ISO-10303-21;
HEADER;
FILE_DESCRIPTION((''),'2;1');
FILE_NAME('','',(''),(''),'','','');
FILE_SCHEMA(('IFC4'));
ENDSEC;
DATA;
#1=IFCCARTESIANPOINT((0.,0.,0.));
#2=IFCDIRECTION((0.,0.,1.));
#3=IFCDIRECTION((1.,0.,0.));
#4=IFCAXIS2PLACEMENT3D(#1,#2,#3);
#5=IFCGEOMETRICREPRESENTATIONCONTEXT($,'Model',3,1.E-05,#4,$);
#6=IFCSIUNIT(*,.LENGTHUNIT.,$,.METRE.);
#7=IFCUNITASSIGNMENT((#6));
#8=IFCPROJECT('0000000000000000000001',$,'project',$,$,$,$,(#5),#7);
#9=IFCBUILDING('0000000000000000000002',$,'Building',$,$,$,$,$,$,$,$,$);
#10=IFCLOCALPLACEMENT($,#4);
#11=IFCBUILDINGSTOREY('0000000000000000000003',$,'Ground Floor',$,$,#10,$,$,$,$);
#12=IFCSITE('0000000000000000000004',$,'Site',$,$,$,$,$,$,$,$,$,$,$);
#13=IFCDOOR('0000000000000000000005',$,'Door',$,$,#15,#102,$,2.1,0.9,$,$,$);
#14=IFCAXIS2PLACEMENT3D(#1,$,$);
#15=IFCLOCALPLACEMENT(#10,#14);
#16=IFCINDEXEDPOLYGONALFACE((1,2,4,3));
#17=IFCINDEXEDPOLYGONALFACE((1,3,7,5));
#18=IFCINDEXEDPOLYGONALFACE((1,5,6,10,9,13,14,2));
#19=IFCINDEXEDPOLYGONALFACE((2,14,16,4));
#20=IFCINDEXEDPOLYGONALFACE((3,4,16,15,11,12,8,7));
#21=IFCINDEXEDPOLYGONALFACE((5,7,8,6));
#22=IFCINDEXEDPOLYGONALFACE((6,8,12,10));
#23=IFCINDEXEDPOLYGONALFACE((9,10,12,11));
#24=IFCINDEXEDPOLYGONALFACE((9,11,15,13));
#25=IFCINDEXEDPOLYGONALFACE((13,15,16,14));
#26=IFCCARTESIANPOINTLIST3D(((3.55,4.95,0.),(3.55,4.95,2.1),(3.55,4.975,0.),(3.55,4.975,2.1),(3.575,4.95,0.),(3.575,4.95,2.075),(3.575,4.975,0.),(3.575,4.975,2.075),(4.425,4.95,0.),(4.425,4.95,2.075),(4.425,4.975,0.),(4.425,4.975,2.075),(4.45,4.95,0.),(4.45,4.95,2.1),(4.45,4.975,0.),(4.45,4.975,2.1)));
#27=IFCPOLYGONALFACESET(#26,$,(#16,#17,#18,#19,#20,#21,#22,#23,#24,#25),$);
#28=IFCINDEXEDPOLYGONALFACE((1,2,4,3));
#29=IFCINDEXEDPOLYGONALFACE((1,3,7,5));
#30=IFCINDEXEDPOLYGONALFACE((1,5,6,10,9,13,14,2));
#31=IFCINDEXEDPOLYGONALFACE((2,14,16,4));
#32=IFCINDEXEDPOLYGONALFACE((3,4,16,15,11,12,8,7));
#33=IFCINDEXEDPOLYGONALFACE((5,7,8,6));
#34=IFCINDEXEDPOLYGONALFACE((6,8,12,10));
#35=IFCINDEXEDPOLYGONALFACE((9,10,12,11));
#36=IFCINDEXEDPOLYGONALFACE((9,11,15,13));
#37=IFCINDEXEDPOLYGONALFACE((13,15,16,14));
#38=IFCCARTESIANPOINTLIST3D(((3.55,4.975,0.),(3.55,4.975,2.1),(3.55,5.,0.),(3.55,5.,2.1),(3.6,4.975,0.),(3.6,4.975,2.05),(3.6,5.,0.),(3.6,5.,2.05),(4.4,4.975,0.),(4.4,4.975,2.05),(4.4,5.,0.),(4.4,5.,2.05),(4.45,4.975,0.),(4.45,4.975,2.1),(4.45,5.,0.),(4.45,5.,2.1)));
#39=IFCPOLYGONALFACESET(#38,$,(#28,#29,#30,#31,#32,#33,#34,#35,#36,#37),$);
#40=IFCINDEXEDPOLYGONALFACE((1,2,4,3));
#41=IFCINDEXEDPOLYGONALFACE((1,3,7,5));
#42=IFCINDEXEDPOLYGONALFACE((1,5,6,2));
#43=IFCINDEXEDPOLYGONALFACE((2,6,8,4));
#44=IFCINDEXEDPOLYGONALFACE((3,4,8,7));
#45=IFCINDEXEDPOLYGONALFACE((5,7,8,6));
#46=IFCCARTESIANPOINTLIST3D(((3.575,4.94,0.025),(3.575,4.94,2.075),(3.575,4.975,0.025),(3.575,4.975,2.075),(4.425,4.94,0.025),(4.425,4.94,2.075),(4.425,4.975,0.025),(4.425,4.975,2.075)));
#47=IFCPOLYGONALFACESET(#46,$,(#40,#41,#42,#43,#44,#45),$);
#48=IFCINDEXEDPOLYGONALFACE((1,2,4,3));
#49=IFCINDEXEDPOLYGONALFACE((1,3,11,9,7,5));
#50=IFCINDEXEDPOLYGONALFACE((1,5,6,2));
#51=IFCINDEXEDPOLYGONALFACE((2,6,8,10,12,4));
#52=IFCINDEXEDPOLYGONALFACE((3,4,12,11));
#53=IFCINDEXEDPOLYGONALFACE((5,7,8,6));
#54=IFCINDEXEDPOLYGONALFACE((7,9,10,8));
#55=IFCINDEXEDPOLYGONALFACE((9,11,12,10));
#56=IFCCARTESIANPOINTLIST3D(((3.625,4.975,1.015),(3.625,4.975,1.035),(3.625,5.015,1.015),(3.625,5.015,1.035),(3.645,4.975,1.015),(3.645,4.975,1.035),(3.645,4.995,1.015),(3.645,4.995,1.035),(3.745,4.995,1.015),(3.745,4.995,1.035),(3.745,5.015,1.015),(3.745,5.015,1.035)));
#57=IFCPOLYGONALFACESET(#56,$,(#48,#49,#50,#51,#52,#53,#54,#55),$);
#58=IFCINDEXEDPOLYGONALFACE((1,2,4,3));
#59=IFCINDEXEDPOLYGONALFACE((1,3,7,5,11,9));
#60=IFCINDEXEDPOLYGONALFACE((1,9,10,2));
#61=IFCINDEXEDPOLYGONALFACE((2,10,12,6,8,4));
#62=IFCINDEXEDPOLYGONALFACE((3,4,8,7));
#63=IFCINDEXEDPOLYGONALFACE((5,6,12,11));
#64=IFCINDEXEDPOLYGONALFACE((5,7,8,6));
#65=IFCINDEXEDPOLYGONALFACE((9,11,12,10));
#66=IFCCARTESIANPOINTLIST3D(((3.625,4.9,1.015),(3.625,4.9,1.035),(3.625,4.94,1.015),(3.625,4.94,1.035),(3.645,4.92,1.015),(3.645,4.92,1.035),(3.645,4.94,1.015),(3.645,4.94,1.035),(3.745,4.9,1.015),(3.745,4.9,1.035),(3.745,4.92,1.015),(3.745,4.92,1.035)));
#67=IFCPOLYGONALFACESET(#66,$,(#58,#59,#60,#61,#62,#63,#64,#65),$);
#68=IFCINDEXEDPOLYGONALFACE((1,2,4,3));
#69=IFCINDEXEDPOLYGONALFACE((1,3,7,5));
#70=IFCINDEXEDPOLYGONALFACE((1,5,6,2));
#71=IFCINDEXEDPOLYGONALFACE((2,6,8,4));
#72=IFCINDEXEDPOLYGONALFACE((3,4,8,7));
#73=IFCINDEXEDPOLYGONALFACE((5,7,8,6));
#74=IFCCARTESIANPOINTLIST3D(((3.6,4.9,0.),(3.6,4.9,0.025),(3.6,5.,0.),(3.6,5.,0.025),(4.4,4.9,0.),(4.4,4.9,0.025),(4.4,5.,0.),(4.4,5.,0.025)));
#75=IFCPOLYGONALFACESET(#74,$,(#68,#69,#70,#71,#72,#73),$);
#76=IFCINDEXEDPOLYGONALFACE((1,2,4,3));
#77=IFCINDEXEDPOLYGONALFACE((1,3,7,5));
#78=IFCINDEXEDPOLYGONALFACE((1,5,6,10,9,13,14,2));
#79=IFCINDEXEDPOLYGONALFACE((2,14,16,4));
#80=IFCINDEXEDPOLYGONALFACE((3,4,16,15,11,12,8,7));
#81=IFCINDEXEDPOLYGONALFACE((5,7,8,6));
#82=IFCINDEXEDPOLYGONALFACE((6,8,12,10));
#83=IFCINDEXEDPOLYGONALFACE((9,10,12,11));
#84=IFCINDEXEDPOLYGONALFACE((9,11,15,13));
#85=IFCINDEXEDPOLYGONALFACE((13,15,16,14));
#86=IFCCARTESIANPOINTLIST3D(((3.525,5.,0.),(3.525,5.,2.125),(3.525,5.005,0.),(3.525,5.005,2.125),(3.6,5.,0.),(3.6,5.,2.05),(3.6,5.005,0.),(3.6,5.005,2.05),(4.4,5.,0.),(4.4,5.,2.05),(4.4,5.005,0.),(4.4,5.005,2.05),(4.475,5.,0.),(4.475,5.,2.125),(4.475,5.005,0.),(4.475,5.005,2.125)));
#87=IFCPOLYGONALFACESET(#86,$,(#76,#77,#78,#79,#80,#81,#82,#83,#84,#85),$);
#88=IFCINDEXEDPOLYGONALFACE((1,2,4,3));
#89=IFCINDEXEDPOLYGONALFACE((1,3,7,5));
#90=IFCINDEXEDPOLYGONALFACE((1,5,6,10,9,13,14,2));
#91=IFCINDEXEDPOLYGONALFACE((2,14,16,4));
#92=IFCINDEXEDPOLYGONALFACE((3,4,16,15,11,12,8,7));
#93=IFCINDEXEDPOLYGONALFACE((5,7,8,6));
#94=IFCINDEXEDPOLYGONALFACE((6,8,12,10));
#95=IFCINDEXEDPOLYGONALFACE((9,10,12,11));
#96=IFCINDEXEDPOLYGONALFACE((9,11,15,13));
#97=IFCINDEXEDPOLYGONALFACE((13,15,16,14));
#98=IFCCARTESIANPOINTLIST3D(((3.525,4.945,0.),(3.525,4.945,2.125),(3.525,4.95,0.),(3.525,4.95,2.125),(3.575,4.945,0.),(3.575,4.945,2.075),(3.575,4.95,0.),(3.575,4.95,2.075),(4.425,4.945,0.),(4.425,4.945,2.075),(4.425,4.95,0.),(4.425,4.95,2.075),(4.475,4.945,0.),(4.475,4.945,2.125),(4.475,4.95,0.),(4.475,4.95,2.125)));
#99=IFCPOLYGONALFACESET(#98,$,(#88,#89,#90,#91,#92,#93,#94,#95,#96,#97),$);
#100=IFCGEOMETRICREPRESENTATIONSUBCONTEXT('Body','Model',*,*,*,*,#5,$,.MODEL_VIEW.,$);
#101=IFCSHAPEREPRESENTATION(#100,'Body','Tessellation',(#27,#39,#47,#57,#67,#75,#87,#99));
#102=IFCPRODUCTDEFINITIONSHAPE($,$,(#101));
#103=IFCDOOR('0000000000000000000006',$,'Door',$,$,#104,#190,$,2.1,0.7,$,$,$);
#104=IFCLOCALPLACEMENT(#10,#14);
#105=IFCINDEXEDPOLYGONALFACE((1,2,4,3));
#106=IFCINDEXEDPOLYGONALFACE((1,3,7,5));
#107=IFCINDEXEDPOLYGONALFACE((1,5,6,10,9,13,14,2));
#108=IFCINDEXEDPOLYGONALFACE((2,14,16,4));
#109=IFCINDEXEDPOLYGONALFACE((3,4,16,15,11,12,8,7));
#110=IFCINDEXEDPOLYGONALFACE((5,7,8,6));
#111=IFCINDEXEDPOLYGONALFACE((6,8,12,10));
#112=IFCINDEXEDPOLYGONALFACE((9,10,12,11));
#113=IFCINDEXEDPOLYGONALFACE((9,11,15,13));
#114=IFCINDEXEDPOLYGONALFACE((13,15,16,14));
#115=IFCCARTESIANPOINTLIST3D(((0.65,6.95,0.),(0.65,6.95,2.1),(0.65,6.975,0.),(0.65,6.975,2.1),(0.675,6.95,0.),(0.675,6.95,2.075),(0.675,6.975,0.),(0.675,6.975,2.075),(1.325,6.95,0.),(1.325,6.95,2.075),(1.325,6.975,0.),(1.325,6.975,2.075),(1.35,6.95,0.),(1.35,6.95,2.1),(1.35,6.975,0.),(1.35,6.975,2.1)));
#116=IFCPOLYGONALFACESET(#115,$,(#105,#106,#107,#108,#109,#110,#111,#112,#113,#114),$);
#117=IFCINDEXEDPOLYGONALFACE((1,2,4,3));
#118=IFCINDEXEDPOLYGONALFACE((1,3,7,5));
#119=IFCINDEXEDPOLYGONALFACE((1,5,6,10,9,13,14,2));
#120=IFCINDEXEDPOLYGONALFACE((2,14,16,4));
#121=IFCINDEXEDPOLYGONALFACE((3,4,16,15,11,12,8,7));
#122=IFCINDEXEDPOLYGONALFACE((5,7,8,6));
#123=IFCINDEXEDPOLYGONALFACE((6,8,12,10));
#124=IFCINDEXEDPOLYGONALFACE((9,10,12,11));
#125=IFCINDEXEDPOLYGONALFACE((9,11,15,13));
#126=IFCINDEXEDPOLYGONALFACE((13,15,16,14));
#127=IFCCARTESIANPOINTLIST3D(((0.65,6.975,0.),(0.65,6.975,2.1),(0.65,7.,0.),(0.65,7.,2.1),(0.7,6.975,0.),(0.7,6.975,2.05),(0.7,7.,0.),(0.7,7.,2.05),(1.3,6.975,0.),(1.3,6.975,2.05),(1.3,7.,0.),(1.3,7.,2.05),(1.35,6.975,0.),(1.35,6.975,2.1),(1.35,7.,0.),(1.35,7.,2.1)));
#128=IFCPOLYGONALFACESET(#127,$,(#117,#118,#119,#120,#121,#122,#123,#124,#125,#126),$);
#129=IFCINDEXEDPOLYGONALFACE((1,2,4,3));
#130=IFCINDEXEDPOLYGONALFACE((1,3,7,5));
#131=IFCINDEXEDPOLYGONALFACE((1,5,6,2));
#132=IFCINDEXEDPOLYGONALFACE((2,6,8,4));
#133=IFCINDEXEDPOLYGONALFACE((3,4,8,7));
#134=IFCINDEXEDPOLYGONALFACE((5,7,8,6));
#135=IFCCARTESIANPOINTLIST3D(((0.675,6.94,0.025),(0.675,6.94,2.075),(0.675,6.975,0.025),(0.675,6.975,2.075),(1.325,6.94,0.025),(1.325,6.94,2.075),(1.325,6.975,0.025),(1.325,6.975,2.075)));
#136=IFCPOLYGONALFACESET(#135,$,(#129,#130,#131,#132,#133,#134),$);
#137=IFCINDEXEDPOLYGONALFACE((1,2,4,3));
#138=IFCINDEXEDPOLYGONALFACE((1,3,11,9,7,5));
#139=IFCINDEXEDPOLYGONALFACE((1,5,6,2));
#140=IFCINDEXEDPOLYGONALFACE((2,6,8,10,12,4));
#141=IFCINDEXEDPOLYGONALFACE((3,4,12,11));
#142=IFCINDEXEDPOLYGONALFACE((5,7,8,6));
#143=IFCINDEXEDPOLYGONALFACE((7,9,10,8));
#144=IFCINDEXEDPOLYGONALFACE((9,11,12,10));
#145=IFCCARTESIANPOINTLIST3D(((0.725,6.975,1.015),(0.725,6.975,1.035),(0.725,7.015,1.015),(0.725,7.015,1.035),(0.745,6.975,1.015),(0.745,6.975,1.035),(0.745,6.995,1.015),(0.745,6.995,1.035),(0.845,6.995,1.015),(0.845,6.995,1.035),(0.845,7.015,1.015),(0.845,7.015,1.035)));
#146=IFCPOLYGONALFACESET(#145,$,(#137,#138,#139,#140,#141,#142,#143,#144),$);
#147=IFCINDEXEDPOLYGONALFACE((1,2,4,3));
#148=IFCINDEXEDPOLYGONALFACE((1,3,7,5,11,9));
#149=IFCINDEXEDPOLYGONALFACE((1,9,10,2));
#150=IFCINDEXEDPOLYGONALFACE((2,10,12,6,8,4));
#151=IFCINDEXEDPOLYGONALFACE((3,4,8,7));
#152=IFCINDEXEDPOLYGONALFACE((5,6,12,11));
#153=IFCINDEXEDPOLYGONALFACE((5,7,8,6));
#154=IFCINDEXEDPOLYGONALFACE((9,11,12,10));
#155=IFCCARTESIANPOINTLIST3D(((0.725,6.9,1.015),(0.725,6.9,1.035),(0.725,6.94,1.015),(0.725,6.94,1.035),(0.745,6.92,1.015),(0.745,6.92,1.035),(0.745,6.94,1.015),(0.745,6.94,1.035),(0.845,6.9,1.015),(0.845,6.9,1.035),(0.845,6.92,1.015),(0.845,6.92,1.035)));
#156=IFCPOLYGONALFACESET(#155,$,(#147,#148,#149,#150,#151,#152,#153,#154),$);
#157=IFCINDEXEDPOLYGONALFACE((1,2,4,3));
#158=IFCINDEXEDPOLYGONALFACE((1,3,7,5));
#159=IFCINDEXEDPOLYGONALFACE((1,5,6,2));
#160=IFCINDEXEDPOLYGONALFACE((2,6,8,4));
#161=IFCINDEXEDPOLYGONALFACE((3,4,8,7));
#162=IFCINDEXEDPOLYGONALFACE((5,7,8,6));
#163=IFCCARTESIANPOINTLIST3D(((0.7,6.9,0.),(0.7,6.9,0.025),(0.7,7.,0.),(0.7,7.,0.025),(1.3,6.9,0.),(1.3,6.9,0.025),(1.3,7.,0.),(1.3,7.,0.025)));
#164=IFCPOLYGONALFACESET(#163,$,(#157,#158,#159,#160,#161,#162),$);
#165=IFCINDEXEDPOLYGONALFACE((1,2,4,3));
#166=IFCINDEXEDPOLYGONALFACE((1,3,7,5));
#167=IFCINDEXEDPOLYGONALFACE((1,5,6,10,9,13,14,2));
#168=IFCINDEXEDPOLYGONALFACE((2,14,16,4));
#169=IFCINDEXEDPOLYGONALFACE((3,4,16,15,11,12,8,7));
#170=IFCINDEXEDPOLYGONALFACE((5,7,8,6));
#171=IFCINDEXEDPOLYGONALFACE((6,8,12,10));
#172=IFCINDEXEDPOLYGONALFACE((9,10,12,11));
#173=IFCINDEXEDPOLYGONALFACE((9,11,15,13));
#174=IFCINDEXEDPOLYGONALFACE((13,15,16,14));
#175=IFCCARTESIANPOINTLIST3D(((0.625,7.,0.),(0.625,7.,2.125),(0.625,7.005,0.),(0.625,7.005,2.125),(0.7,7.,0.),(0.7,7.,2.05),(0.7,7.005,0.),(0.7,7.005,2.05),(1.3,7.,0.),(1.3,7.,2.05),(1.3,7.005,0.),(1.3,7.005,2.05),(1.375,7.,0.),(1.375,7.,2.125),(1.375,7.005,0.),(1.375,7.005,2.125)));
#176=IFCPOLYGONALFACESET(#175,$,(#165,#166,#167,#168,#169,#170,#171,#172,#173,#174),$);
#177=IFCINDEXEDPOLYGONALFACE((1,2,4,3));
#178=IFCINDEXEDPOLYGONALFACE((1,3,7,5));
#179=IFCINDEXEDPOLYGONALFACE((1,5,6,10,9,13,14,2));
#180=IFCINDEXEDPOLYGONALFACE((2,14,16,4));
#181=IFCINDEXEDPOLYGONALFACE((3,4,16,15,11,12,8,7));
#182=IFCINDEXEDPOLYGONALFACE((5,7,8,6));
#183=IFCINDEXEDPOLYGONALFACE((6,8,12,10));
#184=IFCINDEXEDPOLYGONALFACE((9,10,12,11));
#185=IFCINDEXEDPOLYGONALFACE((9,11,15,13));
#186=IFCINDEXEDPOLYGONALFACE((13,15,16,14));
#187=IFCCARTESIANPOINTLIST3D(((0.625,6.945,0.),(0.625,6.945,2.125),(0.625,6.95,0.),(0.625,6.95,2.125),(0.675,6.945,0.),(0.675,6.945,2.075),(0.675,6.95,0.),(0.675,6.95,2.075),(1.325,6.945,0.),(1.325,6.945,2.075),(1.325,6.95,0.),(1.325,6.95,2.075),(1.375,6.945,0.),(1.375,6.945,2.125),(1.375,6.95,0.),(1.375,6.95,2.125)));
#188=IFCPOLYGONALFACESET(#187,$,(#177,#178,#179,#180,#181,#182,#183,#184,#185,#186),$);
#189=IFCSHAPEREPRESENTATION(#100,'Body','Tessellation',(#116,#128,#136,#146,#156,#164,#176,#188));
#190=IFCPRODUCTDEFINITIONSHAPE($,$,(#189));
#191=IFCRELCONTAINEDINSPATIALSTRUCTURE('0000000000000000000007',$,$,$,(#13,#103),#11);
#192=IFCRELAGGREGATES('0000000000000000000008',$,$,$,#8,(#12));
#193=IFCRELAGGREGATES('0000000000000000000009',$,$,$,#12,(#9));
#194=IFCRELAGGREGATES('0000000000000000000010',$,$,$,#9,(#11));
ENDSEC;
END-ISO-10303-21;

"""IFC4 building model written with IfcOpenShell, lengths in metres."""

from ifc_helpers import new_model, si_unit, frame, origin_with_axes, place, context, subcontext, project, spatial, line, indexed_curve, outline, extrude, element, save


model = new_model("IFC4")

# Units and contexts
model_context = context("Model", 3, precision=1e-05, world=origin_with_axes())
body_context = subcontext(model_context, "Body", "Model", "MODEL_VIEW")
ifc_project = project(units=[si_unit("LENGTHUNIT", "METRE")], contexts=[model_context])

# Site, building, storey
site = spatial("IfcSite", under=ifc_project, Name="Site")
building = spatial("IfcBuilding", under=site, Name="Building")
storey_placement = place(None, origin_with_axes())
storey = spatial("IfcBuildingStorey", under=building, at=storey_placement, Name="Ground Floor")

# Doors
door_1_placement = place(storey_placement, frame((4.45, 5.0, 0.0), z_axis=(0.0, 0.0, 1.0), x_axis=(-1.0, 0.0, 0.0)))
element("IfcDoor", 1, at=door_1_placement, inside=storey, Name="Door", OverallHeight=2.1, OverallWidth=0.9, context=body_context, shape_type="SweptSolid", body=[
    extrude(outline(indexed_curve([(0.0, 0.0), (0.0, 2.1), (0.9, 2.1), (0.9, 0.0), (0.875, 0.0), (0.875, 2.075), (0.025, 2.075), (0.025, 0.0)], segments=[line(1, 2, 3, 4, 5, 6, 7, 8, 1)])), frame((0.0, 0.025, 0.0), z_axis=(0.0, -1.0, 0.0), x_axis=(1.0, 0.0, 0.0)), (0.0, 0.0, -1.0), 0.025),
    extrude(outline(indexed_curve([(0.0, 0.0), (0.0, 2.1), (0.9, 2.1), (0.9, 0.0), (0.85, 0.0), (0.85, 2.05), (0.05, 2.05), (0.05, 0.0)], segments=[line(1, 2, 3, 4, 5, 6, 7, 8, 1)])), frame((0.0, 0.0, 0.0), z_axis=(0.0, -1.0, 0.0), x_axis=(1.0, 0.0, 0.0)), (0.0, 0.0, -1.0), 0.025),
    extrude(outline(indexed_curve([(0.0, 0.0), (0.85, 0.0), (0.85, 0.035), (0.0, 0.035)], segments=[line(1, 2, 3, 4, 1)])), frame((0.025, 0.025, 0.025), z_axis=(0.0, 0.0, 1.0), x_axis=(1.0, 0.0, 0.0)), (0.0, 0.0, 1.0), 2.05),
    extrude(outline(indexed_curve([(0.0, 0.0), (0.0, -0.04), (-0.12, -0.04), (-0.12, -0.02), (-0.02, -0.02), (-0.02, 0.0)], segments=[line(1, 2, 3, 4, 5, 6, 1)])), frame((0.825, 0.025, 1.015), z_axis=(0.0, 0.0, 1.0), x_axis=(1.0, 0.0, 0.0)), (0.0, 0.0, 1.0), 0.02),
    extrude(outline(indexed_curve([(0.0, 0.0), (0.0, 0.04), (-0.12, 0.04), (-0.12, 0.02), (-0.02, 0.02), (-0.02, 0.0)], segments=[line(1, 2, 3, 4, 5, 6, 1)])), frame((0.825, 0.06, 1.015), z_axis=(0.0, 0.0, 1.0), x_axis=(1.0, 0.0, 0.0)), (0.0, 0.0, 1.0), 0.02),
    extrude(outline(indexed_curve([(0.0, 0.0), (0.8, 0.0), (0.8, 0.1), (0.0, 0.1)], segments=[line(1, 2, 3, 4, 1)])), frame((0.05, 0.0, 0.0), z_axis=(0.0, 0.0, 1.0), x_axis=(1.0, 0.0, 0.0)), (0.0, 0.0, 1.0), 0.025),
    extrude(outline(indexed_curve([(0.0, 0.0), (0.0, 2.125), (0.95, 2.125), (0.95, 0.0), (0.875, 0.0), (0.875, 2.05), (0.075, 2.05), (0.075, 0.0)], segments=[line(1, 2, 3, 4, 5, 6, 7, 8, 1)])), frame((-0.025, -0.005, 0.0), z_axis=(0.0, -1.0, 0.0), x_axis=(1.0, 0.0, 0.0)), (0.0, 0.0, -1.0), 0.005),
    extrude(outline(indexed_curve([(0.0, 0.0), (0.0, 2.125), (0.95, 2.125), (0.95, 0.0), (0.9, 0.0), (0.9, 2.075), (0.05, 2.075), (0.05, 0.0)], segments=[line(1, 2, 3, 4, 5, 6, 7, 8, 1)])), frame((-0.025, 0.05, 0.0), z_axis=(0.0, -1.0, 0.0), x_axis=(1.0, 0.0, 0.0)), (0.0, 0.0, -1.0), 0.005),
])
door_2_placement = place(storey_placement, frame((1.35, 7.0, 0.0), z_axis=(0.0, 0.0, 1.0), x_axis=(-1.0, 0.0, 0.0)))
element("IfcDoor", 2, at=door_2_placement, inside=storey, Name="Door", OverallHeight=2.1, OverallWidth=0.7, context=body_context, shape_type="SweptSolid", body=[
    extrude(outline(indexed_curve([(0.0, 0.0), (0.0, 2.1), (0.7, 2.1), (0.7, 0.0), (0.675, 0.0), (0.675, 2.075), (0.025, 2.075), (0.025, 0.0)], segments=[line(1, 2, 3, 4, 5, 6, 7, 8, 1)])), frame((0.0, 0.025, 0.0), z_axis=(0.0, -1.0, 0.0), x_axis=(1.0, 0.0, 0.0)), (0.0, 0.0, -1.0), 0.025),
    extrude(outline(indexed_curve([(0.0, 0.0), (0.0, 2.1), (0.7, 2.1), (0.7, 0.0), (0.65, 0.0), (0.65, 2.05), (0.05, 2.05), (0.05, 0.0)], segments=[line(1, 2, 3, 4, 5, 6, 7, 8, 1)])), frame((0.0, 0.0, 0.0), z_axis=(0.0, -1.0, 0.0), x_axis=(1.0, 0.0, 0.0)), (0.0, 0.0, -1.0), 0.025),
    extrude(outline(indexed_curve([(0.0, 0.0), (0.65, 0.0), (0.65, 0.035), (0.0, 0.035)], segments=[line(1, 2, 3, 4, 1)])), frame((0.025, 0.025, 0.025), z_axis=(0.0, 0.0, 1.0), x_axis=(1.0, 0.0, 0.0)), (0.0, 0.0, 1.0), 2.05),
    extrude(outline(indexed_curve([(0.0, 0.0), (0.0, -0.04), (-0.12, -0.04), (-0.12, -0.02), (-0.02, -0.02), (-0.02, 0.0)], segments=[line(1, 2, 3, 4, 5, 6, 1)])), frame((0.625, 0.025, 1.015), z_axis=(0.0, 0.0, 1.0), x_axis=(1.0, 0.0, 0.0)), (0.0, 0.0, 1.0), 0.02),
    extrude(outline(indexed_curve([(0.0, 0.0), (0.0, 0.04), (-0.12, 0.04), (-0.12, 0.02), (-0.02, 0.02), (-0.02, 0.0)], segments=[line(1, 2, 3, 4, 5, 6, 1)])), frame((0.625, 0.06, 1.015), z_axis=(0.0, 0.0, 1.0), x_axis=(1.0, 0.0, 0.0)), (0.0, 0.0, 1.0), 0.02),
    extrude(outline(indexed_curve([(0.0, 0.0), (0.6, 0.0), (0.6, 0.1), (0.0, 0.1)], segments=[line(1, 2, 3, 4, 1)])), frame((0.05, 0.0, 0.0), z_axis=(0.0, 0.0, 1.0), x_axis=(1.0, 0.0, 0.0)), (0.0, 0.0, 1.0), 0.025),
    extrude(outline(indexed_curve([(0.0, 0.0), (0.0, 2.125), (0.75, 2.125), (0.75, 0.0), (0.675, 0.0), (0.675, 2.05), (0.075, 2.05), (0.075, 0.0)], segments=[line(1, 2, 3, 4, 5, 6, 7, 8, 1)])), frame((-0.025, -0.005, 0.0), z_axis=(0.0, -1.0, 0.0), x_axis=(1.0, 0.0, 0.0)), (0.0, 0.0, -1.0), 0.005),
    extrude(outline(indexed_curve([(0.0, 0.0), (0.0, 2.125), (0.75, 2.125), (0.75, 0.0), (0.7, 0.0), (0.7, 2.075), (0.05, 2.075), (0.05, 0.0)], segments=[line(1, 2, 3, 4, 5, 6, 7, 8, 1)])), frame((-0.025, 0.05, 0.0), z_axis=(0.0, -1.0, 0.0), x_axis=(1.0, 0.0, 0.0)), (0.0, 0.0, -1.0), 0.005),
])

save(model, "model.ifc")
